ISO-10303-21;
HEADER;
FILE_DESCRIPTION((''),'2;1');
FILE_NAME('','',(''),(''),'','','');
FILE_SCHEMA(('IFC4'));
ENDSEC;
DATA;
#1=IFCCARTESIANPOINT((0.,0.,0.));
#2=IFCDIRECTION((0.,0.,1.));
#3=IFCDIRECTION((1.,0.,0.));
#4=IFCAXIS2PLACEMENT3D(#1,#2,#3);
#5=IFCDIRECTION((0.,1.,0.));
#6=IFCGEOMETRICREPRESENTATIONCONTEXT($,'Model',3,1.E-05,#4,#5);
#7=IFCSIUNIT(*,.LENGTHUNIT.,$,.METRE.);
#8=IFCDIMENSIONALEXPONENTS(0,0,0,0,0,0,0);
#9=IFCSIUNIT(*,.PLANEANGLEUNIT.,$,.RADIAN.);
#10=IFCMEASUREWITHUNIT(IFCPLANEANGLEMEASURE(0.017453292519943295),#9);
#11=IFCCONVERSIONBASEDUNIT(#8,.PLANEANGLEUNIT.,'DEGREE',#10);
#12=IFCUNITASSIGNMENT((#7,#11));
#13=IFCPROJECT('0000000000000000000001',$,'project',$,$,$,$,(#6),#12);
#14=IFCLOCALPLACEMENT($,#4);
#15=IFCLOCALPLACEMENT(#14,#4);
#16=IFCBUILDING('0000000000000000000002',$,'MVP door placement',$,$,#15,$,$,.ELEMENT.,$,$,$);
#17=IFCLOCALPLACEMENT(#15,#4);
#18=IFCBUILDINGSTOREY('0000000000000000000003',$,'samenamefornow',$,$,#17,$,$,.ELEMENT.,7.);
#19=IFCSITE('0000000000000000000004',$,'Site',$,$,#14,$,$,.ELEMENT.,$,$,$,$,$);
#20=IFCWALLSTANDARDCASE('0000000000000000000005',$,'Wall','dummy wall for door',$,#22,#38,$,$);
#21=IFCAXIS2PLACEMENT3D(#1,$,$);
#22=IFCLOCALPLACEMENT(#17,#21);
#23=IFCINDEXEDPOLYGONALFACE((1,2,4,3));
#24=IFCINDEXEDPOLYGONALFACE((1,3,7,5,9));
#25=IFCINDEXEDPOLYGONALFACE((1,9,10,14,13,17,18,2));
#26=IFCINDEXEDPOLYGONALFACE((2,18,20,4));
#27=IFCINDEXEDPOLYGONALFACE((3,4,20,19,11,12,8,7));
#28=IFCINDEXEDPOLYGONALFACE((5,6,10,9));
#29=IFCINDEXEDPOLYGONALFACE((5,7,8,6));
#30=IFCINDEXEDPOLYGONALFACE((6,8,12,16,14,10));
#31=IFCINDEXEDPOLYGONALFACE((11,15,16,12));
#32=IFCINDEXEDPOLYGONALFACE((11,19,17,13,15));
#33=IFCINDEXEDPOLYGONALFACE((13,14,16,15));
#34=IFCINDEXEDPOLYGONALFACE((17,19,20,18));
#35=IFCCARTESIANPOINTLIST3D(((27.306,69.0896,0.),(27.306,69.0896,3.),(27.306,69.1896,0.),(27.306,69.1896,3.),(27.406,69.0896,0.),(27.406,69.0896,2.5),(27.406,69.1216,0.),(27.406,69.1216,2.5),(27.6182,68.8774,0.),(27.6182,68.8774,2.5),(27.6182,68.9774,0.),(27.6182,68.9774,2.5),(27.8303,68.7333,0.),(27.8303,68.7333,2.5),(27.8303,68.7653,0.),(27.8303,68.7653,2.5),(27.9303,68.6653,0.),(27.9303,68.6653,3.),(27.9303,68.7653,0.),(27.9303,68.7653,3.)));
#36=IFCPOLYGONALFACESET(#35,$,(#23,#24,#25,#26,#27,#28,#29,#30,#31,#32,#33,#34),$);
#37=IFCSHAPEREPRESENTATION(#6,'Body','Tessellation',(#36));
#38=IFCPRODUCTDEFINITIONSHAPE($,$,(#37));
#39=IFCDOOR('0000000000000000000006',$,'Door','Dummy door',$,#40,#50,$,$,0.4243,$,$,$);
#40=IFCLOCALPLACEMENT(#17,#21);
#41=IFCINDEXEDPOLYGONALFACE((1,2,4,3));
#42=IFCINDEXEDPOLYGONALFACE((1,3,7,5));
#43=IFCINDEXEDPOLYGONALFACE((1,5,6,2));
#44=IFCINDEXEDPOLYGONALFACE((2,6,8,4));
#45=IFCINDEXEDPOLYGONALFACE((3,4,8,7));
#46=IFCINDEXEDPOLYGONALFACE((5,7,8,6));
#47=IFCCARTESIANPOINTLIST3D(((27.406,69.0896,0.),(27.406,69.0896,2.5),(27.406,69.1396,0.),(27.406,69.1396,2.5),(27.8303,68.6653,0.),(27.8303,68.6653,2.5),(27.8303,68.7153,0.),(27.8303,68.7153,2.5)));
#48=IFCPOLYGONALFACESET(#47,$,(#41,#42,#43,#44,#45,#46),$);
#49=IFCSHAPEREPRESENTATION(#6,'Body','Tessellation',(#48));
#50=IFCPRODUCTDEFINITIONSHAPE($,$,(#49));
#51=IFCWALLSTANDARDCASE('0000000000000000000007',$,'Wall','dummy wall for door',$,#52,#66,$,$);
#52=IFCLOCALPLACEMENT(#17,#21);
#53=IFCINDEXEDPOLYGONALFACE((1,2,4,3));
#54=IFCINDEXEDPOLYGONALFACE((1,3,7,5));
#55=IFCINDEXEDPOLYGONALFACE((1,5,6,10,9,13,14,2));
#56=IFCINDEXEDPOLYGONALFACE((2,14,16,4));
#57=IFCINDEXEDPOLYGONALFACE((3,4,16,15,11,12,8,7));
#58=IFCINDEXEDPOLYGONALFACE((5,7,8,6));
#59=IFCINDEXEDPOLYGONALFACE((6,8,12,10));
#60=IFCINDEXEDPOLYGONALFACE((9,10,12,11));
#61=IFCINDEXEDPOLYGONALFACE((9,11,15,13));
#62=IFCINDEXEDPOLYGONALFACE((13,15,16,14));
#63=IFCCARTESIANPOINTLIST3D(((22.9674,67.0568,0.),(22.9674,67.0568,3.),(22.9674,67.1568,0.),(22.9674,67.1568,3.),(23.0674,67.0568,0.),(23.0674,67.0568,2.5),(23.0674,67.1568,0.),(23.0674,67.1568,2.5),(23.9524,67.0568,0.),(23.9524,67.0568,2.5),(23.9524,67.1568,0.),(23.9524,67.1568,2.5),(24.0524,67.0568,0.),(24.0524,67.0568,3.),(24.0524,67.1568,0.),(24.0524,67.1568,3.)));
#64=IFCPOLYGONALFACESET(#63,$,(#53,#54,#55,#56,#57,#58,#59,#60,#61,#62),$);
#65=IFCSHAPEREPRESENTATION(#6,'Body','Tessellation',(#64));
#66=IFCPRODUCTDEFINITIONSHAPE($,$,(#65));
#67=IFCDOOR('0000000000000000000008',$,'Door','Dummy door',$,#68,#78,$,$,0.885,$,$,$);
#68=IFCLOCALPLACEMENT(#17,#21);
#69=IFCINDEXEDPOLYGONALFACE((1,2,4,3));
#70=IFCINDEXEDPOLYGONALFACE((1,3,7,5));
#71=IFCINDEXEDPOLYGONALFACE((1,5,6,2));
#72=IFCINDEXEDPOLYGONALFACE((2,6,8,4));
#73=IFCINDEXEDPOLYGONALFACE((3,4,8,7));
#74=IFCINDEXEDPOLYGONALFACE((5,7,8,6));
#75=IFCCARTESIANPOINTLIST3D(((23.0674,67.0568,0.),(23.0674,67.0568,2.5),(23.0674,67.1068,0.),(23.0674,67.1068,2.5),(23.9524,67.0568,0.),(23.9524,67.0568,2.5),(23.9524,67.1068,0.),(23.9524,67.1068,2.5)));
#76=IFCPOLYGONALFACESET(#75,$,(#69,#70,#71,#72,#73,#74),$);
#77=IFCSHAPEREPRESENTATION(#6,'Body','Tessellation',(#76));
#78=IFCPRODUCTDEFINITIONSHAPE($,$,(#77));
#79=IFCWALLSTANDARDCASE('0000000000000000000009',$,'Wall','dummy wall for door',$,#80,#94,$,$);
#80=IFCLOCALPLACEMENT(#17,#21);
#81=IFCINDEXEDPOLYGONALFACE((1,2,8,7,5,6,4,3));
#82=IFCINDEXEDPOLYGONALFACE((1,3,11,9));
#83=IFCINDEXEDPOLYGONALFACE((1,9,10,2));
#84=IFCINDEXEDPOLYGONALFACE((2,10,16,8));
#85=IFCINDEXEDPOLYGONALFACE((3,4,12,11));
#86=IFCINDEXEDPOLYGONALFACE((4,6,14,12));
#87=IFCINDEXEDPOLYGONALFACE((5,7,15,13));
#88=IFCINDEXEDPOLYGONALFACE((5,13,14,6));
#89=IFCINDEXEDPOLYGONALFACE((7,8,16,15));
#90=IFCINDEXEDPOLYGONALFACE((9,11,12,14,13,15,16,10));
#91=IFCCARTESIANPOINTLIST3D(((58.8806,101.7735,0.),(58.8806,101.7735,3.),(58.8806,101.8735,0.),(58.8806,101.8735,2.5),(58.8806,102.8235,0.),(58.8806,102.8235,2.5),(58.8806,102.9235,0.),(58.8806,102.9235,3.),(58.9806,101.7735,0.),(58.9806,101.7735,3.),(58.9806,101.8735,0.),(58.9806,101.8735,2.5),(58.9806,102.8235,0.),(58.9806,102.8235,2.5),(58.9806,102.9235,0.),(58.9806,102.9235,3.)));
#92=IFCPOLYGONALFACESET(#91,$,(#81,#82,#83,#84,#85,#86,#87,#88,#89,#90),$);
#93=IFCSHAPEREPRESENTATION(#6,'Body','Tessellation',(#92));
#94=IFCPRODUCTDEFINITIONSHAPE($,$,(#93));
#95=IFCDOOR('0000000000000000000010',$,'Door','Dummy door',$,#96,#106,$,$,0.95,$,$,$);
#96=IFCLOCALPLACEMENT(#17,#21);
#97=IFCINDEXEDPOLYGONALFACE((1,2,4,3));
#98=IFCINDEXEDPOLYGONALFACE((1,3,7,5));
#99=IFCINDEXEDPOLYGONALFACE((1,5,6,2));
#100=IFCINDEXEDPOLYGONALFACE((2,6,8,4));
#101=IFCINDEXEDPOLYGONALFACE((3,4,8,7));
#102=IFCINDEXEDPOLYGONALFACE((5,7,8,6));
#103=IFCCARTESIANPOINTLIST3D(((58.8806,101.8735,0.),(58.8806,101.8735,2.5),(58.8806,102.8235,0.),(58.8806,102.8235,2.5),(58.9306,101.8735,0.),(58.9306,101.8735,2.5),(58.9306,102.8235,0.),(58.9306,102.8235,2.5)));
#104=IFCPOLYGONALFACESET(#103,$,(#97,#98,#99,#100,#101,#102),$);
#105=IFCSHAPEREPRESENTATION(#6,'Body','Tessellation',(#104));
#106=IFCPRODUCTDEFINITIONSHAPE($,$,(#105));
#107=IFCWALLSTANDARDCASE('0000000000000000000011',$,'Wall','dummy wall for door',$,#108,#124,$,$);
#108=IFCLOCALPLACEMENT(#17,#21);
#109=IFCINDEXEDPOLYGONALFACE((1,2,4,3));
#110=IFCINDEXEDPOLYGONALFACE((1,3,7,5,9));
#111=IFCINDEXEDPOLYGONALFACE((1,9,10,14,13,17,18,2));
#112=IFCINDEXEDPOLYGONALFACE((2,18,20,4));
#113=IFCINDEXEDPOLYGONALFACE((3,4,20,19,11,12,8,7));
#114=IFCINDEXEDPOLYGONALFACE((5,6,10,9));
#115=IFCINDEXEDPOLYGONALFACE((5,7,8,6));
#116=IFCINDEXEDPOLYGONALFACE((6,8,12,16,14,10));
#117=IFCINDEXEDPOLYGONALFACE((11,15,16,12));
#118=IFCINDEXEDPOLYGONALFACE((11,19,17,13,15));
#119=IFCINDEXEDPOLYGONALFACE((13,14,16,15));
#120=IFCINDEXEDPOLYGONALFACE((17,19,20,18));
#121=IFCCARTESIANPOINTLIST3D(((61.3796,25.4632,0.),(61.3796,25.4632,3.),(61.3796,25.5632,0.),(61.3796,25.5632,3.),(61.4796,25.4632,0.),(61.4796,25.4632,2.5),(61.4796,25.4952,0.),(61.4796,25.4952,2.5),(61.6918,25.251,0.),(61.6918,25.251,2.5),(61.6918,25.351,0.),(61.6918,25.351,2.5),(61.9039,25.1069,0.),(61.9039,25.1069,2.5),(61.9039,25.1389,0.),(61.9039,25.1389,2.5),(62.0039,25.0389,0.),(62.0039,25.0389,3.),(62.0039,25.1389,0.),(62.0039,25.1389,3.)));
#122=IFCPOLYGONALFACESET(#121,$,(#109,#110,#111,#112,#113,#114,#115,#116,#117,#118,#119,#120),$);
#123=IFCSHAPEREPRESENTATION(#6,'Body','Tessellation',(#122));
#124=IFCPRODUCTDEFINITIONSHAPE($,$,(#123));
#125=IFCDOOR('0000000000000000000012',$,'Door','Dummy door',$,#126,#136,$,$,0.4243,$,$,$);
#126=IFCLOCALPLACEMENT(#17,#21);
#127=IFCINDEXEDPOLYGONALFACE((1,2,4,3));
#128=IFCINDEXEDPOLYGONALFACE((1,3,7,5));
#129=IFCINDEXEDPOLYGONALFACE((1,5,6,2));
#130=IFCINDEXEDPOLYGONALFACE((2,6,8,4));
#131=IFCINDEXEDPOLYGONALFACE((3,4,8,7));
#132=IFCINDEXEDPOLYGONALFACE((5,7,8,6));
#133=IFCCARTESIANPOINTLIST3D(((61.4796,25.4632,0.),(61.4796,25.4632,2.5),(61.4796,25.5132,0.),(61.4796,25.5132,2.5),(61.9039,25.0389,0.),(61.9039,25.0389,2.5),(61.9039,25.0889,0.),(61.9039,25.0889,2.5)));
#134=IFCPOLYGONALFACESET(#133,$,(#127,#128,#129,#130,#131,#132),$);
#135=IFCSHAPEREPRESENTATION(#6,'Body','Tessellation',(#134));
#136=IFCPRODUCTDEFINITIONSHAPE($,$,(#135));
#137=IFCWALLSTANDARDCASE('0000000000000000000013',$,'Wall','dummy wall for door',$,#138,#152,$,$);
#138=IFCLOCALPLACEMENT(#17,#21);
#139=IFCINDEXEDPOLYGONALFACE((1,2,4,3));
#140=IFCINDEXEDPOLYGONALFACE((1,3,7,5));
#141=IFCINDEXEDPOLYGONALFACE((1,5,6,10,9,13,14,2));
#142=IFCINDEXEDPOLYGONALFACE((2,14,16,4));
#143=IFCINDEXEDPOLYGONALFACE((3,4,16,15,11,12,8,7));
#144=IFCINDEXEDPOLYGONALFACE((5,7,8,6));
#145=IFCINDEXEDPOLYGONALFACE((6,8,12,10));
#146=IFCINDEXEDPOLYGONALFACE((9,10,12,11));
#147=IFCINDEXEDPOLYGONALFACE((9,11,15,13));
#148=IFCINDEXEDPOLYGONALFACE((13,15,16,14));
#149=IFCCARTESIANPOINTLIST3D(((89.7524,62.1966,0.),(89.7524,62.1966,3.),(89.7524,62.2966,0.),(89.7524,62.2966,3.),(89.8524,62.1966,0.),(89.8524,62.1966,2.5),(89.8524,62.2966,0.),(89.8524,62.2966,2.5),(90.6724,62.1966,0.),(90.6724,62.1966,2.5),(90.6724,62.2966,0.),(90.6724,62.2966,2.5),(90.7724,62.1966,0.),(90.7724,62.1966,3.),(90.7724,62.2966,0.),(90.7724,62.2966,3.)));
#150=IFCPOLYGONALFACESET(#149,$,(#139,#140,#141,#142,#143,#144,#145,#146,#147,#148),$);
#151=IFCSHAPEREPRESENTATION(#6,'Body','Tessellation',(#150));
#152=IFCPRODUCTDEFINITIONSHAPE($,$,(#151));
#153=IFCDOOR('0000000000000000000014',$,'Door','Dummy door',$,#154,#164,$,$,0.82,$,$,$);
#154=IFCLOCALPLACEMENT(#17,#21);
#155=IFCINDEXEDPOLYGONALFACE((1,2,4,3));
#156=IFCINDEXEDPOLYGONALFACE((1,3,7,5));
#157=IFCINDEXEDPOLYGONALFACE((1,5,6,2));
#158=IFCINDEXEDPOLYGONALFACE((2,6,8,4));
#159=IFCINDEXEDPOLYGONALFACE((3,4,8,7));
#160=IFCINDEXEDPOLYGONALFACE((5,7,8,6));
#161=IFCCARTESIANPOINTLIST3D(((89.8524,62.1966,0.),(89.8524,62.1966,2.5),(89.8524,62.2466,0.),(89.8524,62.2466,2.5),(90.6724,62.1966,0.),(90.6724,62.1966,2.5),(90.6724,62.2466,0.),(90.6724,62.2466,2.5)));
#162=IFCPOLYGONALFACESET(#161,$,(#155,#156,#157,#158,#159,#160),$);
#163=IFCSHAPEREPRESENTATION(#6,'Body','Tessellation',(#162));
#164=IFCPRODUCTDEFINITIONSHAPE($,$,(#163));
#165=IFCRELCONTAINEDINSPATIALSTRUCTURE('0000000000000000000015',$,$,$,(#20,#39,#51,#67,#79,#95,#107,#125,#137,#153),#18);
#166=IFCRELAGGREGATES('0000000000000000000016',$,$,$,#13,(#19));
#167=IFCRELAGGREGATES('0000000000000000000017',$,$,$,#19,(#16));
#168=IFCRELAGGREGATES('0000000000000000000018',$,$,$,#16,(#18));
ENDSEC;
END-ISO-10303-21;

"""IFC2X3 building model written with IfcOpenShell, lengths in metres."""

from ifc_helpers import new_model, entity, si_unit, converted_unit, direction, origin_with_axes, place, context, project, spatial, polyline, outline, extrude, element, fill, save


model = new_model("IFC2X3")

# Units and contexts
model_context = context("Model", 3, precision=1e-05, world=origin_with_axes(), true_north=direction((0.0, 1.0, 0.0)))
ifc_project = project(units=[si_unit("LENGTHUNIT", "METRE"), converted_unit("PLANEANGLEUNIT", "DEGREE", entity("IfcPlaneAngleMeasure", 0.017453292519943295), si_unit("PLANEANGLEUNIT", "RADIAN"), dimensions=[0, 0, 0, 0, 0, 0, 0])], contexts=[model_context])

# Site, building, storey
site_placement = place(None, origin_with_axes())
site = spatial("IfcSite", under=ifc_project, at=site_placement, Name="Site", CompositionType="ELEMENT")
building_placement = place(site_placement, origin_with_axes())
building = spatial("IfcBuilding", under=site, at=building_placement, Name="MVP door placement", CompositionType="ELEMENT")
storey_placement = place(building_placement, origin_with_axes())
storey = spatial("IfcBuildingStorey", under=building, at=storey_placement, Name="samenamefornow", CompositionType="ELEMENT", Elevation=7.0)

# Walls, openings, doors
wall_1_placement = place(storey_placement, origin_with_axes())
wall_1 = element("IfcWallStandardCase", 1, at=wall_1_placement, inside=storey, Name="Wall", Description="dummy wall for door", context=model_context, shape_type="SweptSolid", body=[
    extrude(outline(polyline([(27.306, 69.0896, 0.0), (27.9303, 68.6653, 0.0), (27.9303, 68.7653, 0.0), (27.306, 69.1896, 0.0), (27.306, 69.0896, 0.0)])), origin_with_axes(), (0.0, 0.0, 1.0), 3.0),
])
opening_1_placement = place(wall_1_placement, origin_with_axes())
opening_1 = element("IfcOpeningElement", 2, at=opening_1_placement, cuts=wall_1, context=model_context, shape_type="SweptSolid", body=[
    extrude(outline(polyline([(27.406, 69.0896, 0.0), (27.8303, 68.6653, 0.0), (27.8303, 68.7653, 0.0), (27.406, 69.1896, 0.0), (27.406, 69.0896, 0.0)])), origin_with_axes(), (0.0, 0.0, 1.0), 2.5),
])
door_1_placement = place(opening_1_placement, origin_with_axes())
door_1 = element("IfcDoor", 3, at=door_1_placement, inside=storey, Name="Door", Description="Dummy door", OverallWidth=0.4243, context=model_context, shape_type="SweptSolid", body=[
    extrude(outline(polyline([(27.406, 69.0896, 0.0), (27.8303, 68.6653, 0.0), (27.8303, 68.7153, 0.0), (27.406, 69.1396, 0.0), (27.406, 69.0896, 0.0)])), origin_with_axes(), (0.0, 0.0, 1.0), 2.5),
])
fill(opening_1, door_1)
wall_2_placement = place(storey_placement, origin_with_axes())
wall_2 = element("IfcWallStandardCase", 4, at=wall_2_placement, inside=storey, Name="Wall", Description="dummy wall for door", context=model_context, shape_type="SweptSolid", body=[
    extrude(outline(polyline([(22.9674, 67.0568, 0.0), (24.0524, 67.0568, 0.0), (24.0524, 67.1568, 0.0), (22.9674, 67.1568, 0.0), (22.9674, 67.0568, 0.0)])), origin_with_axes(), (0.0, 0.0, 1.0), 3.0),
])
opening_2_placement = place(wall_2_placement, origin_with_axes())
opening_2 = element("IfcOpeningElement", 5, at=opening_2_placement, cuts=wall_2, context=model_context, shape_type="SweptSolid", body=[
    extrude(outline(polyline([(23.0674, 67.0568, 0.0), (23.9524, 67.0568, 0.0), (23.9524, 67.1568, 0.0), (23.0674, 67.1568, 0.0), (23.0674, 67.0568, 0.0)])), origin_with_axes(), (0.0, 0.0, 1.0), 2.5),
])
door_2_placement = place(opening_2_placement, origin_with_axes())
door_2 = element("IfcDoor", 6, at=door_2_placement, inside=storey, Name="Door", Description="Dummy door", OverallWidth=0.885, context=model_context, shape_type="SweptSolid", body=[
    extrude(outline(polyline([(23.0674, 67.0568, 0.0), (23.9524, 67.0568, 0.0), (23.9524, 67.1068, 0.0), (23.0674, 67.1068, 0.0), (23.0674, 67.0568, 0.0)])), origin_with_axes(), (0.0, 0.0, 1.0), 2.5),
])
fill(opening_2, door_2)
wall_3_placement = place(storey_placement, origin_with_axes())
wall_3 = element("IfcWallStandardCase", 7, at=wall_3_placement, inside=storey, Name="Wall", Description="dummy wall for door", context=model_context, shape_type="SweptSolid", body=[
    extrude(outline(polyline([(58.8806, 101.7735, 0.0), (58.8806, 102.9235, 0.0), (58.9806, 102.9235, 0.0), (58.9806, 101.7735, 0.0), (58.8806, 101.7735, 0.0)])), origin_with_axes(), (0.0, 0.0, 1.0), 3.0),
])
opening_3_placement = place(wall_3_placement, origin_with_axes())
opening_3 = element("IfcOpeningElement", 8, at=opening_3_placement, cuts=wall_3, context=model_context, shape_type="SweptSolid", body=[
    extrude(outline(polyline([(58.8806, 101.8735, 0.0), (58.8806, 102.8235, 0.0), (58.9806, 102.8235, 0.0), (58.9806, 101.8735, 0.0), (58.8806, 101.8735, 0.0)])), origin_with_axes(), (0.0, 0.0, 1.0), 2.5),
])
door_3_placement = place(opening_3_placement, origin_with_axes())
door_3 = element("IfcDoor", 9, at=door_3_placement, inside=storey, Name="Door", Description="Dummy door", OverallWidth=0.95, context=model_context, shape_type="SweptSolid", body=[
    extrude(outline(polyline([(58.8806, 101.8735, 0.0), (58.8806, 102.8235, 0.0), (58.9306, 102.8235, 0.0), (58.9306, 101.8735, 0.0), (58.8806, 101.8735, 0.0)])), origin_with_axes(), (0.0, 0.0, 1.0), 2.5),
])
fill(opening_3, door_3)
wall_4_placement = place(storey_placement, origin_with_axes())
wall_4 = element("IfcWallStandardCase", 10, at=wall_4_placement, inside=storey, Name="Wall", Description="dummy wall for door", context=model_context, shape_type="SweptSolid", body=[
    extrude(outline(polyline([(61.3796, 25.4632, 0.0), (62.0039, 25.0389, 0.0), (62.0039, 25.1389, 0.0), (61.3796, 25.5632, 0.0), (61.3796, 25.4632, 0.0)])), origin_with_axes(), (0.0, 0.0, 1.0), 3.0),
])
opening_4_placement = place(wall_4_placement, origin_with_axes())
opening_4 = element("IfcOpeningElement", 11, at=opening_4_placement, cuts=wall_4, context=model_context, shape_type="SweptSolid", body=[
    extrude(outline(polyline([(61.4796, 25.4632, 0.0), (61.9039, 25.0389, 0.0), (61.9039, 25.1389, 0.0), (61.4796, 25.5632, 0.0), (61.4796, 25.4632, 0.0)])), origin_with_axes(), (0.0, 0.0, 1.0), 2.5),
])
door_4_placement = place(opening_4_placement, origin_with_axes())
door_4 = element("IfcDoor", 12, at=door_4_placement, inside=storey, Name="Door", Description="Dummy door", OverallWidth=0.4243, context=model_context, shape_type="SweptSolid", body=[
    extrude(outline(polyline([(61.4796, 25.4632, 0.0), (61.9039, 25.0389, 0.0), (61.9039, 25.0889, 0.0), (61.4796, 25.5132, 0.0), (61.4796, 25.4632, 0.0)])), origin_with_axes(), (0.0, 0.0, 1.0), 2.5),
])
fill(opening_4, door_4)
wall_5_placement = place(storey_placement, origin_with_axes())
wall_5 = element("IfcWallStandardCase", 13, at=wall_5_placement, inside=storey, Name="Wall", Description="dummy wall for door", context=model_context, shape_type="SweptSolid", body=[
    extrude(outline(polyline([(90.7724, 62.1966, 0.0), (89.7524, 62.1966, 0.0), (89.7524, 62.2966, 0.0), (90.7724, 62.2966, 0.0), (90.7724, 62.1966, 0.0)])), origin_with_axes(), (0.0, 0.0, 1.0), 3.0),
])
opening_5_placement = place(wall_5_placement, origin_with_axes())
opening_5 = element("IfcOpeningElement", 14, at=opening_5_placement, cuts=wall_5, context=model_context, shape_type="SweptSolid", body=[
    extrude(outline(polyline([(90.6724, 62.1966, 0.0), (89.8524, 62.1966, 0.0), (89.8524, 62.2966, 0.0), (90.6724, 62.2966, 0.0), (90.6724, 62.1966, 0.0)])), origin_with_axes(), (0.0, 0.0, 1.0), 2.5),
])
door_5_placement = place(opening_5_placement, origin_with_axes())
door_5 = element("IfcDoor", 15, at=door_5_placement, inside=storey, Name="Door", Description="Dummy door", OverallWidth=0.82, context=model_context, shape_type="SweptSolid", body=[
    extrude(outline(polyline([(90.6724, 62.1966, 0.0), (89.8524, 62.1966, 0.0), (89.8524, 62.2466, 0.0), (90.6724, 62.2466, 0.0), (90.6724, 62.1966, 0.0)])), origin_with_axes(), (0.0, 0.0, 1.0), 2.5),
])
fill(opening_5, door_5)

save(model, "model.ifc")
